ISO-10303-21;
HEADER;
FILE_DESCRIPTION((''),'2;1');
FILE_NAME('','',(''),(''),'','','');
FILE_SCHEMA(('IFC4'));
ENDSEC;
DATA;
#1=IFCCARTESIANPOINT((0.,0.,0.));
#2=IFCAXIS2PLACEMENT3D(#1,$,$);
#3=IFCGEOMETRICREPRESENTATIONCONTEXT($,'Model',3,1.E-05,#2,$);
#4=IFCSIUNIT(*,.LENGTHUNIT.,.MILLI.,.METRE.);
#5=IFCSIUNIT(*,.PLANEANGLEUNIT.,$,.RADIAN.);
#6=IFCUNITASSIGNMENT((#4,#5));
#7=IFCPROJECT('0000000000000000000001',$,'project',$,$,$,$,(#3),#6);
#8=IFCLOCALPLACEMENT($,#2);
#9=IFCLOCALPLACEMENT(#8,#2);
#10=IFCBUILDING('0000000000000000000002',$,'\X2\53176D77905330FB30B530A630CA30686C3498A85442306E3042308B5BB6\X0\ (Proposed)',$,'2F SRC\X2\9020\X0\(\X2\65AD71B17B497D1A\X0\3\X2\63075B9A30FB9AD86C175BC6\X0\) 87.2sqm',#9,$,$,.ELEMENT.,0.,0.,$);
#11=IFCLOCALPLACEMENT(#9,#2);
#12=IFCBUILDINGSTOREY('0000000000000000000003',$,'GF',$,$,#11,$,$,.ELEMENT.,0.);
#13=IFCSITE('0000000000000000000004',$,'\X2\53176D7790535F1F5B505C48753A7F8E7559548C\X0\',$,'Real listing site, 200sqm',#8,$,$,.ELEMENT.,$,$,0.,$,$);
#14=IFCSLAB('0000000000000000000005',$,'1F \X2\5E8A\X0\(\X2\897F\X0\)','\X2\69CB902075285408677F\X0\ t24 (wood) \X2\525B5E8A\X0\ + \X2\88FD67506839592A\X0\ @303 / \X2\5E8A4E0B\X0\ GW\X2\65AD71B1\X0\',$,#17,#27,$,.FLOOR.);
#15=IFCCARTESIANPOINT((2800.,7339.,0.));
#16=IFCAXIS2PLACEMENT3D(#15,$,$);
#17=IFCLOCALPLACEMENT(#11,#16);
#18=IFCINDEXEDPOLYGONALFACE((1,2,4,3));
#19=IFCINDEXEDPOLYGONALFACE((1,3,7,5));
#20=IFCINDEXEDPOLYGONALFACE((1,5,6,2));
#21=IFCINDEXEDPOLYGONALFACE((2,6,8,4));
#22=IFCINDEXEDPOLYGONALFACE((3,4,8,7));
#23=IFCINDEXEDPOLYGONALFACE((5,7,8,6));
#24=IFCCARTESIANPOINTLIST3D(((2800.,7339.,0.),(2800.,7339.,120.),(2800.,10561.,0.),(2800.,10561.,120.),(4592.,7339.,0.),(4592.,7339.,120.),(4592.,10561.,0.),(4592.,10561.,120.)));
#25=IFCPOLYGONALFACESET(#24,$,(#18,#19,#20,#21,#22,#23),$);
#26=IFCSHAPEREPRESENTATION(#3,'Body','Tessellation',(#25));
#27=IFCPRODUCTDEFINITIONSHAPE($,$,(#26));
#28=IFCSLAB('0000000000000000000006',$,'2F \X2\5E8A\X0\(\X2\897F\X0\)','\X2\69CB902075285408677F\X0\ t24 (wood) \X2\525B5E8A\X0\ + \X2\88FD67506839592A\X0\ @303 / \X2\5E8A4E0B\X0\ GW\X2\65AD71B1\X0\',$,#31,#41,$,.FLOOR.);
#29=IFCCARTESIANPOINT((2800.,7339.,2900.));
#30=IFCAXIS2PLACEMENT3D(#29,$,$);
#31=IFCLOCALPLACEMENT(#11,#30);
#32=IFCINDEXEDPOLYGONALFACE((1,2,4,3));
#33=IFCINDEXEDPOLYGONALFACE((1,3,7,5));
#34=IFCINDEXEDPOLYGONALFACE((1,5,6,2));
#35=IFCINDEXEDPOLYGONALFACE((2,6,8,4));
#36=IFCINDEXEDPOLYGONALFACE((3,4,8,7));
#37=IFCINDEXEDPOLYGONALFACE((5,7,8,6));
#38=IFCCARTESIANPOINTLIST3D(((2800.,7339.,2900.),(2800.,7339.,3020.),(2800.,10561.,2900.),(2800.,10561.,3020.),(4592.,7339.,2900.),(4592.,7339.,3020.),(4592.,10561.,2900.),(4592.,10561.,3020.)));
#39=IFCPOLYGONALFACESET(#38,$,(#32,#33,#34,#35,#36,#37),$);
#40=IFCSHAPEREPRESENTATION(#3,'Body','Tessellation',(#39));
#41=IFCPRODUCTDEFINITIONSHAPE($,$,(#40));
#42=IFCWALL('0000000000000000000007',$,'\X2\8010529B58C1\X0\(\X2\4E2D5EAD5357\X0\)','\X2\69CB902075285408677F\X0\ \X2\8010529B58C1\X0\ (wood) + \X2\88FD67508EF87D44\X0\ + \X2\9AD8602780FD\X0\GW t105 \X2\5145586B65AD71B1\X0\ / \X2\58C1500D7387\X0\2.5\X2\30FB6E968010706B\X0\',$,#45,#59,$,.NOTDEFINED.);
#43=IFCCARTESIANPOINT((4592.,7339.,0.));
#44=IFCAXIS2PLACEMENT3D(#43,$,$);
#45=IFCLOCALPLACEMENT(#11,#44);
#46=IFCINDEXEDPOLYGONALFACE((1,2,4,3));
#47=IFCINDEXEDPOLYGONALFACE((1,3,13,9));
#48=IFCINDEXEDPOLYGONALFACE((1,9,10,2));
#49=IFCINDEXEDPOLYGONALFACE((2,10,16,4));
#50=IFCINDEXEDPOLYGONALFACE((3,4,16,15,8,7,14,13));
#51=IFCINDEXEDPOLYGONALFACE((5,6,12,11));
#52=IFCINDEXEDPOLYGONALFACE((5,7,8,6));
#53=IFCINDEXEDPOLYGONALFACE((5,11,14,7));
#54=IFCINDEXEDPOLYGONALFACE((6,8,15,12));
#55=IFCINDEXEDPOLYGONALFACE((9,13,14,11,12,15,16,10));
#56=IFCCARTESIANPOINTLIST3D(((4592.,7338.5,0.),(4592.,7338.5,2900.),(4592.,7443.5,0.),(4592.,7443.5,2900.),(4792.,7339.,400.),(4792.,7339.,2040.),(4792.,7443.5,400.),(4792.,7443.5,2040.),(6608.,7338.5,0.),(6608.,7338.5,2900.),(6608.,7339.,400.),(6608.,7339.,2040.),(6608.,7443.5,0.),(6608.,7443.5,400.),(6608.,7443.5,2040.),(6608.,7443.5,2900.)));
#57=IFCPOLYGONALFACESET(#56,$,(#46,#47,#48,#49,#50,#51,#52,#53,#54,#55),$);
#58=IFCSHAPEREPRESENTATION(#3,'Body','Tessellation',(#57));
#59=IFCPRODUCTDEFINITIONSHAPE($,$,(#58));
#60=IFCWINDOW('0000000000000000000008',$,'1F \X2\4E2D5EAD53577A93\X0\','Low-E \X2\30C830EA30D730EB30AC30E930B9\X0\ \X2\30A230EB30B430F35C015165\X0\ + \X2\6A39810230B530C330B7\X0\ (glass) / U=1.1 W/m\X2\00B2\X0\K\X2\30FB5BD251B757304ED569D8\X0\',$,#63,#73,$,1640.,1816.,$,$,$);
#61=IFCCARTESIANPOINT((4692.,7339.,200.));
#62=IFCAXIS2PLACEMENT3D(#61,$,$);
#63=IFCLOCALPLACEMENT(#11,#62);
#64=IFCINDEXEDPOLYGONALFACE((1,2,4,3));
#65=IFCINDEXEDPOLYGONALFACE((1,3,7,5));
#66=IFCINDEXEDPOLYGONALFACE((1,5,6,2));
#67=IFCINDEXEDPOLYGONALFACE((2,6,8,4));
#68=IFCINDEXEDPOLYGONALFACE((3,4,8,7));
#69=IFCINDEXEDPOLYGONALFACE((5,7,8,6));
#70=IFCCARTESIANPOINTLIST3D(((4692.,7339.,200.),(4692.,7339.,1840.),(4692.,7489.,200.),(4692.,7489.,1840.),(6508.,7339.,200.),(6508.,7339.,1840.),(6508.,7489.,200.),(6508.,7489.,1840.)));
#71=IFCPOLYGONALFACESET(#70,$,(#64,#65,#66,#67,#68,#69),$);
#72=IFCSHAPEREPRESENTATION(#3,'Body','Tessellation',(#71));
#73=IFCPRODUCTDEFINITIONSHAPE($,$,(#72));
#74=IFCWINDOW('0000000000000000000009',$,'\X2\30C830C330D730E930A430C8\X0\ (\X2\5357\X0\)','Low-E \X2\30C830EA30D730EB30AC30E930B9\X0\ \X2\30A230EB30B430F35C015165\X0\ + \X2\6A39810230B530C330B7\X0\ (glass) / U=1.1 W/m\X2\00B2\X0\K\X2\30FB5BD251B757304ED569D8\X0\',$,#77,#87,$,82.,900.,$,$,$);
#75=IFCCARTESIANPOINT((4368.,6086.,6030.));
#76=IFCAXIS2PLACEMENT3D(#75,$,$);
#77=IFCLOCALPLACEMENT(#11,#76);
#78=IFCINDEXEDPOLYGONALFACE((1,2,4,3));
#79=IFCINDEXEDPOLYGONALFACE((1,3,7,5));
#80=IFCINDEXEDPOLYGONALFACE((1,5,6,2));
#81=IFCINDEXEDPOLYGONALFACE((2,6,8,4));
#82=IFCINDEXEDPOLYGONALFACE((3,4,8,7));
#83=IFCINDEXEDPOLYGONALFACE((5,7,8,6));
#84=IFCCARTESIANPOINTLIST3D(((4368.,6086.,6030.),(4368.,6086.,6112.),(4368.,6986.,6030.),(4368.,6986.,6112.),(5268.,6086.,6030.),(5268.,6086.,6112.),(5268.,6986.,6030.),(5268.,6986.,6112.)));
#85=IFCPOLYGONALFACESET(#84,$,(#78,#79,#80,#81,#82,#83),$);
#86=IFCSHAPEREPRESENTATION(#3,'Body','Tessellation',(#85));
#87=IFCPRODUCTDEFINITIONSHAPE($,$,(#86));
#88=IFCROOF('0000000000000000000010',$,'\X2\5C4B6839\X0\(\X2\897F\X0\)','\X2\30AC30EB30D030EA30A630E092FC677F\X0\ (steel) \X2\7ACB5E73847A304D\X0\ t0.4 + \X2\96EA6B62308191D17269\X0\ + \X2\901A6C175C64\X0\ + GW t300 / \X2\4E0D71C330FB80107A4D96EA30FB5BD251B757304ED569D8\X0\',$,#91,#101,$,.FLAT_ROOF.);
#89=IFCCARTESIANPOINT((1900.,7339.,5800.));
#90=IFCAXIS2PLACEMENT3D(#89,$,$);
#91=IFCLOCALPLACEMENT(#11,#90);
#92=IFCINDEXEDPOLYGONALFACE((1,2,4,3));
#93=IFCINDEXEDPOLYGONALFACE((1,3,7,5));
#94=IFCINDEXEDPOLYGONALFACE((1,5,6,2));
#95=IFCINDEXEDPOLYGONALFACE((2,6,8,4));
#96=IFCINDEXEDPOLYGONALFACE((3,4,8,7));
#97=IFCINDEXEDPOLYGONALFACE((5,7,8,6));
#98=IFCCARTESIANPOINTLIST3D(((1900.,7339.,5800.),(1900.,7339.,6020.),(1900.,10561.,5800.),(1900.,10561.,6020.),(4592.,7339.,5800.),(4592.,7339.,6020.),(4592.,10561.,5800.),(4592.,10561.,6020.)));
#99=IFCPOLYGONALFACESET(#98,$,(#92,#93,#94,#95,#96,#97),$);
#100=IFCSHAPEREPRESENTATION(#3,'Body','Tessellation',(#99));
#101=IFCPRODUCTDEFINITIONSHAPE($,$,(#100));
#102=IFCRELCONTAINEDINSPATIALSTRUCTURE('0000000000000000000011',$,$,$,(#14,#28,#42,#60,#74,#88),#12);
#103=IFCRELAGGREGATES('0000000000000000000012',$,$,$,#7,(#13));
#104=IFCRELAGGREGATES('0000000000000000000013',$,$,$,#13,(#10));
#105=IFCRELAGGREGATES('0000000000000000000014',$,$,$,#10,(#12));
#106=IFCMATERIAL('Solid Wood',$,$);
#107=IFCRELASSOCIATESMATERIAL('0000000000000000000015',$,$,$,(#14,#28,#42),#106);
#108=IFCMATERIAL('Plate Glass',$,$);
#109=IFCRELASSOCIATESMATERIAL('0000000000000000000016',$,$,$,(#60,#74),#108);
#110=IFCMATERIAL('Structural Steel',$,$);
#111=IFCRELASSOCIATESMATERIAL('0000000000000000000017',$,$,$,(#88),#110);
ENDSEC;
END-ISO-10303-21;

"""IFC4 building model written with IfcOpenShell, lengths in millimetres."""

from ifc_helpers import new_model, si_unit, frame, frame_2d, origin, place, context, project, spatial, rectangle, extrude, material, element, fill, save


model = new_model("IFC4")

# Units and contexts
model_context = context("Model", 3, precision=1e-05, world=origin())
ifc_project = project(units=[si_unit("LENGTHUNIT", "METRE", prefix="MILLI"), si_unit("PLANEANGLEUNIT", "RADIAN")], contexts=[model_context])

# Site, building, storey
site_placement = place(None, origin())
site = spatial("IfcSite", under=ifc_project, at=site_placement, Name="北海道弟子屈町美留和", ObjectType="Real listing site, 200sqm", CompositionType="ELEMENT", RefElevation=0.0)
building_placement = place(site_placement, origin())
building = spatial("IfcBuilding", under=site, at=building_placement, Name="北海道・サウナと水風呂のある家 (Proposed)", ObjectType="2F SRC造(断熱等級3指定・高気密) 87.2sqm", CompositionType="ELEMENT", ElevationOfRefHeight=0.0, ElevationOfTerrain=0.0)
storey_placement = place(building_placement, origin())
storey = spatial("IfcBuildingStorey", under=building, at=storey_placement, Name="GF", CompositionType="ELEMENT", Elevation=0.0)

# Shared definitions
ifc_material_1 = material(Name="Solid Wood")

# Slabs
slab_1_placement = place(storey_placement, frame((2800.0, 7339.0, 0.0)))
element("IfcSlab", 1, at=slab_1_placement, inside=storey, material=ifc_material_1, Name="1F 床(西)", Description="構造用合板 t24 (wood) 剛床 + 製材根太 @303 / 床下 GW断熱", PredefinedType="FLOOR", context=model_context, shape_type="SweptSolid", body=[
    extrude(rectangle(XDim=1792.0, YDim=3222.0, at=frame_2d((896.0, 1611.0))), frame((2800.0, 7339.0, 0.0)), (0.0, 0.0, 1.0), 120.0),
])
slab_2_placement = place(storey_placement, frame((2800.0, 7339.0, 2900.0)))
element("IfcSlab", 2, at=slab_2_placement, inside=storey, material=ifc_material_1, Name="2F 床(西)", Description="構造用合板 t24 (wood) 剛床 + 製材根太 @303 / 床下 GW断熱", PredefinedType="FLOOR", context=model_context, shape_type="SweptSolid", body=[
    extrude(rectangle(XDim=1792.0, YDim=3222.0, at=frame_2d((896.0, 1611.0))), frame((2800.0, 7339.0, 2900.0)), (0.0, 0.0, 1.0), 120.0),
])

# Wall, opening, window
wall_1_placement = place(storey_placement, frame((4592.0, 7339.0, 0.0)))
wall_1 = element("IfcWall", 3, at=wall_1_placement, inside=storey, material=ifc_material_1, Name="耐力壁(中庭南)", Description="構造用合板 耐力壁 (wood) + 製材軸組 + 高性能GW t105 充填断熱 / 壁倍率2.5・準耐火", PredefinedType="NOTDEFINED", context=model_context, shape_type="SweptSolid", body=[
    extrude(rectangle(XDim=2016.0, YDim=105.0, at=frame_2d((1008.0, 52.0))), frame((4592.0, 7339.0, 0.0)), (0.0, 0.0, 1.0), 2900.0),
])
opening_placement = place(storey_placement, frame((4692.0, 7339.0, 200.0)))
opening = element("IfcOpeningElement", 4, at=opening_placement, cuts=wall_1, PredefinedType="NOTDEFINED", context=model_context, shape_type="SweptSolid", body=[
    extrude(rectangle(XDim=1816.0, YDim=150.0, at=frame_2d((908.0, 75.0))), frame((4692.0, 7339.0, 200.0)), (0.0, 0.0, 1.0), 1640.0),
])
ifc_material_2 = material(Name="Plate Glass")
window_1_placement = place(storey_placement, frame((4692.0, 7339.0, 200.0)))
window_1 = element("IfcWindow", 5, at=window_1_placement, inside=storey, material=ifc_material_2, Name="1F 中庭南窓", Description="Low-E トリプルガラス アルゴン封入 + 樹脂サッシ (glass) / U=1.1 W/m²K・寒冷地仕様", OverallHeight=1640.0, OverallWidth=1816.0, context=model_context, shape_type="SweptSolid", body=[
    extrude(rectangle(XDim=1816.0, YDim=150.0, at=frame_2d((908.0, 75.0))), frame((4692.0, 7339.0, 200.0)), (0.0, 0.0, 1.0), 1640.0),
])
fill(opening, window_1)

# Window
window_2_placement = place(storey_placement, frame((4368.0, 6086.0, 6030.0)))
element("IfcWindow", 6, at=window_2_placement, inside=storey, material=ifc_material_2, Name="トップライト (南)", Description="Low-E トリプルガラス アルゴン封入 + 樹脂サッシ (glass) / U=1.1 W/m²K・寒冷地仕様", OverallHeight=82.0, OverallWidth=900.0, context=model_context, shape_type="SweptSolid", body=[
    extrude(rectangle(XDim=900.0, YDim=900.0, at=frame_2d((450.0, 450.0))), frame((4368.0, 6086.0, 6030.0)), (0.0, 0.0, 1.0), 82.0),
])

# Roof
ifc_material_3 = material(Name="Structural Steel")
for number, where, name in (
    (7, (1900.0, 7339.0, 5800.0), "屋根(西)"),
):
    element("IfcRoof", number, at=place(storey_placement, frame(where)), inside=storey, material=ifc_material_3, Name=name, Description="ガルバリウム鋼板 (steel) 立平葺き t0.4 + 雪止め金物 + 通気層 + GW t300 / 不燃・耐積雪・寒冷地仕様", PredefinedType="FLAT_ROOF", context=model_context, shape_type="SweptSolid", body=[
        extrude(rectangle(XDim=2692.0, YDim=3222.0, at=frame_2d((1346.0, 1611.0))), frame((1900.0, 7339.0, 5800.0)), (0.0, 0.0, 1.0), 220.0),
    ])

save(model, "model.ifc")
